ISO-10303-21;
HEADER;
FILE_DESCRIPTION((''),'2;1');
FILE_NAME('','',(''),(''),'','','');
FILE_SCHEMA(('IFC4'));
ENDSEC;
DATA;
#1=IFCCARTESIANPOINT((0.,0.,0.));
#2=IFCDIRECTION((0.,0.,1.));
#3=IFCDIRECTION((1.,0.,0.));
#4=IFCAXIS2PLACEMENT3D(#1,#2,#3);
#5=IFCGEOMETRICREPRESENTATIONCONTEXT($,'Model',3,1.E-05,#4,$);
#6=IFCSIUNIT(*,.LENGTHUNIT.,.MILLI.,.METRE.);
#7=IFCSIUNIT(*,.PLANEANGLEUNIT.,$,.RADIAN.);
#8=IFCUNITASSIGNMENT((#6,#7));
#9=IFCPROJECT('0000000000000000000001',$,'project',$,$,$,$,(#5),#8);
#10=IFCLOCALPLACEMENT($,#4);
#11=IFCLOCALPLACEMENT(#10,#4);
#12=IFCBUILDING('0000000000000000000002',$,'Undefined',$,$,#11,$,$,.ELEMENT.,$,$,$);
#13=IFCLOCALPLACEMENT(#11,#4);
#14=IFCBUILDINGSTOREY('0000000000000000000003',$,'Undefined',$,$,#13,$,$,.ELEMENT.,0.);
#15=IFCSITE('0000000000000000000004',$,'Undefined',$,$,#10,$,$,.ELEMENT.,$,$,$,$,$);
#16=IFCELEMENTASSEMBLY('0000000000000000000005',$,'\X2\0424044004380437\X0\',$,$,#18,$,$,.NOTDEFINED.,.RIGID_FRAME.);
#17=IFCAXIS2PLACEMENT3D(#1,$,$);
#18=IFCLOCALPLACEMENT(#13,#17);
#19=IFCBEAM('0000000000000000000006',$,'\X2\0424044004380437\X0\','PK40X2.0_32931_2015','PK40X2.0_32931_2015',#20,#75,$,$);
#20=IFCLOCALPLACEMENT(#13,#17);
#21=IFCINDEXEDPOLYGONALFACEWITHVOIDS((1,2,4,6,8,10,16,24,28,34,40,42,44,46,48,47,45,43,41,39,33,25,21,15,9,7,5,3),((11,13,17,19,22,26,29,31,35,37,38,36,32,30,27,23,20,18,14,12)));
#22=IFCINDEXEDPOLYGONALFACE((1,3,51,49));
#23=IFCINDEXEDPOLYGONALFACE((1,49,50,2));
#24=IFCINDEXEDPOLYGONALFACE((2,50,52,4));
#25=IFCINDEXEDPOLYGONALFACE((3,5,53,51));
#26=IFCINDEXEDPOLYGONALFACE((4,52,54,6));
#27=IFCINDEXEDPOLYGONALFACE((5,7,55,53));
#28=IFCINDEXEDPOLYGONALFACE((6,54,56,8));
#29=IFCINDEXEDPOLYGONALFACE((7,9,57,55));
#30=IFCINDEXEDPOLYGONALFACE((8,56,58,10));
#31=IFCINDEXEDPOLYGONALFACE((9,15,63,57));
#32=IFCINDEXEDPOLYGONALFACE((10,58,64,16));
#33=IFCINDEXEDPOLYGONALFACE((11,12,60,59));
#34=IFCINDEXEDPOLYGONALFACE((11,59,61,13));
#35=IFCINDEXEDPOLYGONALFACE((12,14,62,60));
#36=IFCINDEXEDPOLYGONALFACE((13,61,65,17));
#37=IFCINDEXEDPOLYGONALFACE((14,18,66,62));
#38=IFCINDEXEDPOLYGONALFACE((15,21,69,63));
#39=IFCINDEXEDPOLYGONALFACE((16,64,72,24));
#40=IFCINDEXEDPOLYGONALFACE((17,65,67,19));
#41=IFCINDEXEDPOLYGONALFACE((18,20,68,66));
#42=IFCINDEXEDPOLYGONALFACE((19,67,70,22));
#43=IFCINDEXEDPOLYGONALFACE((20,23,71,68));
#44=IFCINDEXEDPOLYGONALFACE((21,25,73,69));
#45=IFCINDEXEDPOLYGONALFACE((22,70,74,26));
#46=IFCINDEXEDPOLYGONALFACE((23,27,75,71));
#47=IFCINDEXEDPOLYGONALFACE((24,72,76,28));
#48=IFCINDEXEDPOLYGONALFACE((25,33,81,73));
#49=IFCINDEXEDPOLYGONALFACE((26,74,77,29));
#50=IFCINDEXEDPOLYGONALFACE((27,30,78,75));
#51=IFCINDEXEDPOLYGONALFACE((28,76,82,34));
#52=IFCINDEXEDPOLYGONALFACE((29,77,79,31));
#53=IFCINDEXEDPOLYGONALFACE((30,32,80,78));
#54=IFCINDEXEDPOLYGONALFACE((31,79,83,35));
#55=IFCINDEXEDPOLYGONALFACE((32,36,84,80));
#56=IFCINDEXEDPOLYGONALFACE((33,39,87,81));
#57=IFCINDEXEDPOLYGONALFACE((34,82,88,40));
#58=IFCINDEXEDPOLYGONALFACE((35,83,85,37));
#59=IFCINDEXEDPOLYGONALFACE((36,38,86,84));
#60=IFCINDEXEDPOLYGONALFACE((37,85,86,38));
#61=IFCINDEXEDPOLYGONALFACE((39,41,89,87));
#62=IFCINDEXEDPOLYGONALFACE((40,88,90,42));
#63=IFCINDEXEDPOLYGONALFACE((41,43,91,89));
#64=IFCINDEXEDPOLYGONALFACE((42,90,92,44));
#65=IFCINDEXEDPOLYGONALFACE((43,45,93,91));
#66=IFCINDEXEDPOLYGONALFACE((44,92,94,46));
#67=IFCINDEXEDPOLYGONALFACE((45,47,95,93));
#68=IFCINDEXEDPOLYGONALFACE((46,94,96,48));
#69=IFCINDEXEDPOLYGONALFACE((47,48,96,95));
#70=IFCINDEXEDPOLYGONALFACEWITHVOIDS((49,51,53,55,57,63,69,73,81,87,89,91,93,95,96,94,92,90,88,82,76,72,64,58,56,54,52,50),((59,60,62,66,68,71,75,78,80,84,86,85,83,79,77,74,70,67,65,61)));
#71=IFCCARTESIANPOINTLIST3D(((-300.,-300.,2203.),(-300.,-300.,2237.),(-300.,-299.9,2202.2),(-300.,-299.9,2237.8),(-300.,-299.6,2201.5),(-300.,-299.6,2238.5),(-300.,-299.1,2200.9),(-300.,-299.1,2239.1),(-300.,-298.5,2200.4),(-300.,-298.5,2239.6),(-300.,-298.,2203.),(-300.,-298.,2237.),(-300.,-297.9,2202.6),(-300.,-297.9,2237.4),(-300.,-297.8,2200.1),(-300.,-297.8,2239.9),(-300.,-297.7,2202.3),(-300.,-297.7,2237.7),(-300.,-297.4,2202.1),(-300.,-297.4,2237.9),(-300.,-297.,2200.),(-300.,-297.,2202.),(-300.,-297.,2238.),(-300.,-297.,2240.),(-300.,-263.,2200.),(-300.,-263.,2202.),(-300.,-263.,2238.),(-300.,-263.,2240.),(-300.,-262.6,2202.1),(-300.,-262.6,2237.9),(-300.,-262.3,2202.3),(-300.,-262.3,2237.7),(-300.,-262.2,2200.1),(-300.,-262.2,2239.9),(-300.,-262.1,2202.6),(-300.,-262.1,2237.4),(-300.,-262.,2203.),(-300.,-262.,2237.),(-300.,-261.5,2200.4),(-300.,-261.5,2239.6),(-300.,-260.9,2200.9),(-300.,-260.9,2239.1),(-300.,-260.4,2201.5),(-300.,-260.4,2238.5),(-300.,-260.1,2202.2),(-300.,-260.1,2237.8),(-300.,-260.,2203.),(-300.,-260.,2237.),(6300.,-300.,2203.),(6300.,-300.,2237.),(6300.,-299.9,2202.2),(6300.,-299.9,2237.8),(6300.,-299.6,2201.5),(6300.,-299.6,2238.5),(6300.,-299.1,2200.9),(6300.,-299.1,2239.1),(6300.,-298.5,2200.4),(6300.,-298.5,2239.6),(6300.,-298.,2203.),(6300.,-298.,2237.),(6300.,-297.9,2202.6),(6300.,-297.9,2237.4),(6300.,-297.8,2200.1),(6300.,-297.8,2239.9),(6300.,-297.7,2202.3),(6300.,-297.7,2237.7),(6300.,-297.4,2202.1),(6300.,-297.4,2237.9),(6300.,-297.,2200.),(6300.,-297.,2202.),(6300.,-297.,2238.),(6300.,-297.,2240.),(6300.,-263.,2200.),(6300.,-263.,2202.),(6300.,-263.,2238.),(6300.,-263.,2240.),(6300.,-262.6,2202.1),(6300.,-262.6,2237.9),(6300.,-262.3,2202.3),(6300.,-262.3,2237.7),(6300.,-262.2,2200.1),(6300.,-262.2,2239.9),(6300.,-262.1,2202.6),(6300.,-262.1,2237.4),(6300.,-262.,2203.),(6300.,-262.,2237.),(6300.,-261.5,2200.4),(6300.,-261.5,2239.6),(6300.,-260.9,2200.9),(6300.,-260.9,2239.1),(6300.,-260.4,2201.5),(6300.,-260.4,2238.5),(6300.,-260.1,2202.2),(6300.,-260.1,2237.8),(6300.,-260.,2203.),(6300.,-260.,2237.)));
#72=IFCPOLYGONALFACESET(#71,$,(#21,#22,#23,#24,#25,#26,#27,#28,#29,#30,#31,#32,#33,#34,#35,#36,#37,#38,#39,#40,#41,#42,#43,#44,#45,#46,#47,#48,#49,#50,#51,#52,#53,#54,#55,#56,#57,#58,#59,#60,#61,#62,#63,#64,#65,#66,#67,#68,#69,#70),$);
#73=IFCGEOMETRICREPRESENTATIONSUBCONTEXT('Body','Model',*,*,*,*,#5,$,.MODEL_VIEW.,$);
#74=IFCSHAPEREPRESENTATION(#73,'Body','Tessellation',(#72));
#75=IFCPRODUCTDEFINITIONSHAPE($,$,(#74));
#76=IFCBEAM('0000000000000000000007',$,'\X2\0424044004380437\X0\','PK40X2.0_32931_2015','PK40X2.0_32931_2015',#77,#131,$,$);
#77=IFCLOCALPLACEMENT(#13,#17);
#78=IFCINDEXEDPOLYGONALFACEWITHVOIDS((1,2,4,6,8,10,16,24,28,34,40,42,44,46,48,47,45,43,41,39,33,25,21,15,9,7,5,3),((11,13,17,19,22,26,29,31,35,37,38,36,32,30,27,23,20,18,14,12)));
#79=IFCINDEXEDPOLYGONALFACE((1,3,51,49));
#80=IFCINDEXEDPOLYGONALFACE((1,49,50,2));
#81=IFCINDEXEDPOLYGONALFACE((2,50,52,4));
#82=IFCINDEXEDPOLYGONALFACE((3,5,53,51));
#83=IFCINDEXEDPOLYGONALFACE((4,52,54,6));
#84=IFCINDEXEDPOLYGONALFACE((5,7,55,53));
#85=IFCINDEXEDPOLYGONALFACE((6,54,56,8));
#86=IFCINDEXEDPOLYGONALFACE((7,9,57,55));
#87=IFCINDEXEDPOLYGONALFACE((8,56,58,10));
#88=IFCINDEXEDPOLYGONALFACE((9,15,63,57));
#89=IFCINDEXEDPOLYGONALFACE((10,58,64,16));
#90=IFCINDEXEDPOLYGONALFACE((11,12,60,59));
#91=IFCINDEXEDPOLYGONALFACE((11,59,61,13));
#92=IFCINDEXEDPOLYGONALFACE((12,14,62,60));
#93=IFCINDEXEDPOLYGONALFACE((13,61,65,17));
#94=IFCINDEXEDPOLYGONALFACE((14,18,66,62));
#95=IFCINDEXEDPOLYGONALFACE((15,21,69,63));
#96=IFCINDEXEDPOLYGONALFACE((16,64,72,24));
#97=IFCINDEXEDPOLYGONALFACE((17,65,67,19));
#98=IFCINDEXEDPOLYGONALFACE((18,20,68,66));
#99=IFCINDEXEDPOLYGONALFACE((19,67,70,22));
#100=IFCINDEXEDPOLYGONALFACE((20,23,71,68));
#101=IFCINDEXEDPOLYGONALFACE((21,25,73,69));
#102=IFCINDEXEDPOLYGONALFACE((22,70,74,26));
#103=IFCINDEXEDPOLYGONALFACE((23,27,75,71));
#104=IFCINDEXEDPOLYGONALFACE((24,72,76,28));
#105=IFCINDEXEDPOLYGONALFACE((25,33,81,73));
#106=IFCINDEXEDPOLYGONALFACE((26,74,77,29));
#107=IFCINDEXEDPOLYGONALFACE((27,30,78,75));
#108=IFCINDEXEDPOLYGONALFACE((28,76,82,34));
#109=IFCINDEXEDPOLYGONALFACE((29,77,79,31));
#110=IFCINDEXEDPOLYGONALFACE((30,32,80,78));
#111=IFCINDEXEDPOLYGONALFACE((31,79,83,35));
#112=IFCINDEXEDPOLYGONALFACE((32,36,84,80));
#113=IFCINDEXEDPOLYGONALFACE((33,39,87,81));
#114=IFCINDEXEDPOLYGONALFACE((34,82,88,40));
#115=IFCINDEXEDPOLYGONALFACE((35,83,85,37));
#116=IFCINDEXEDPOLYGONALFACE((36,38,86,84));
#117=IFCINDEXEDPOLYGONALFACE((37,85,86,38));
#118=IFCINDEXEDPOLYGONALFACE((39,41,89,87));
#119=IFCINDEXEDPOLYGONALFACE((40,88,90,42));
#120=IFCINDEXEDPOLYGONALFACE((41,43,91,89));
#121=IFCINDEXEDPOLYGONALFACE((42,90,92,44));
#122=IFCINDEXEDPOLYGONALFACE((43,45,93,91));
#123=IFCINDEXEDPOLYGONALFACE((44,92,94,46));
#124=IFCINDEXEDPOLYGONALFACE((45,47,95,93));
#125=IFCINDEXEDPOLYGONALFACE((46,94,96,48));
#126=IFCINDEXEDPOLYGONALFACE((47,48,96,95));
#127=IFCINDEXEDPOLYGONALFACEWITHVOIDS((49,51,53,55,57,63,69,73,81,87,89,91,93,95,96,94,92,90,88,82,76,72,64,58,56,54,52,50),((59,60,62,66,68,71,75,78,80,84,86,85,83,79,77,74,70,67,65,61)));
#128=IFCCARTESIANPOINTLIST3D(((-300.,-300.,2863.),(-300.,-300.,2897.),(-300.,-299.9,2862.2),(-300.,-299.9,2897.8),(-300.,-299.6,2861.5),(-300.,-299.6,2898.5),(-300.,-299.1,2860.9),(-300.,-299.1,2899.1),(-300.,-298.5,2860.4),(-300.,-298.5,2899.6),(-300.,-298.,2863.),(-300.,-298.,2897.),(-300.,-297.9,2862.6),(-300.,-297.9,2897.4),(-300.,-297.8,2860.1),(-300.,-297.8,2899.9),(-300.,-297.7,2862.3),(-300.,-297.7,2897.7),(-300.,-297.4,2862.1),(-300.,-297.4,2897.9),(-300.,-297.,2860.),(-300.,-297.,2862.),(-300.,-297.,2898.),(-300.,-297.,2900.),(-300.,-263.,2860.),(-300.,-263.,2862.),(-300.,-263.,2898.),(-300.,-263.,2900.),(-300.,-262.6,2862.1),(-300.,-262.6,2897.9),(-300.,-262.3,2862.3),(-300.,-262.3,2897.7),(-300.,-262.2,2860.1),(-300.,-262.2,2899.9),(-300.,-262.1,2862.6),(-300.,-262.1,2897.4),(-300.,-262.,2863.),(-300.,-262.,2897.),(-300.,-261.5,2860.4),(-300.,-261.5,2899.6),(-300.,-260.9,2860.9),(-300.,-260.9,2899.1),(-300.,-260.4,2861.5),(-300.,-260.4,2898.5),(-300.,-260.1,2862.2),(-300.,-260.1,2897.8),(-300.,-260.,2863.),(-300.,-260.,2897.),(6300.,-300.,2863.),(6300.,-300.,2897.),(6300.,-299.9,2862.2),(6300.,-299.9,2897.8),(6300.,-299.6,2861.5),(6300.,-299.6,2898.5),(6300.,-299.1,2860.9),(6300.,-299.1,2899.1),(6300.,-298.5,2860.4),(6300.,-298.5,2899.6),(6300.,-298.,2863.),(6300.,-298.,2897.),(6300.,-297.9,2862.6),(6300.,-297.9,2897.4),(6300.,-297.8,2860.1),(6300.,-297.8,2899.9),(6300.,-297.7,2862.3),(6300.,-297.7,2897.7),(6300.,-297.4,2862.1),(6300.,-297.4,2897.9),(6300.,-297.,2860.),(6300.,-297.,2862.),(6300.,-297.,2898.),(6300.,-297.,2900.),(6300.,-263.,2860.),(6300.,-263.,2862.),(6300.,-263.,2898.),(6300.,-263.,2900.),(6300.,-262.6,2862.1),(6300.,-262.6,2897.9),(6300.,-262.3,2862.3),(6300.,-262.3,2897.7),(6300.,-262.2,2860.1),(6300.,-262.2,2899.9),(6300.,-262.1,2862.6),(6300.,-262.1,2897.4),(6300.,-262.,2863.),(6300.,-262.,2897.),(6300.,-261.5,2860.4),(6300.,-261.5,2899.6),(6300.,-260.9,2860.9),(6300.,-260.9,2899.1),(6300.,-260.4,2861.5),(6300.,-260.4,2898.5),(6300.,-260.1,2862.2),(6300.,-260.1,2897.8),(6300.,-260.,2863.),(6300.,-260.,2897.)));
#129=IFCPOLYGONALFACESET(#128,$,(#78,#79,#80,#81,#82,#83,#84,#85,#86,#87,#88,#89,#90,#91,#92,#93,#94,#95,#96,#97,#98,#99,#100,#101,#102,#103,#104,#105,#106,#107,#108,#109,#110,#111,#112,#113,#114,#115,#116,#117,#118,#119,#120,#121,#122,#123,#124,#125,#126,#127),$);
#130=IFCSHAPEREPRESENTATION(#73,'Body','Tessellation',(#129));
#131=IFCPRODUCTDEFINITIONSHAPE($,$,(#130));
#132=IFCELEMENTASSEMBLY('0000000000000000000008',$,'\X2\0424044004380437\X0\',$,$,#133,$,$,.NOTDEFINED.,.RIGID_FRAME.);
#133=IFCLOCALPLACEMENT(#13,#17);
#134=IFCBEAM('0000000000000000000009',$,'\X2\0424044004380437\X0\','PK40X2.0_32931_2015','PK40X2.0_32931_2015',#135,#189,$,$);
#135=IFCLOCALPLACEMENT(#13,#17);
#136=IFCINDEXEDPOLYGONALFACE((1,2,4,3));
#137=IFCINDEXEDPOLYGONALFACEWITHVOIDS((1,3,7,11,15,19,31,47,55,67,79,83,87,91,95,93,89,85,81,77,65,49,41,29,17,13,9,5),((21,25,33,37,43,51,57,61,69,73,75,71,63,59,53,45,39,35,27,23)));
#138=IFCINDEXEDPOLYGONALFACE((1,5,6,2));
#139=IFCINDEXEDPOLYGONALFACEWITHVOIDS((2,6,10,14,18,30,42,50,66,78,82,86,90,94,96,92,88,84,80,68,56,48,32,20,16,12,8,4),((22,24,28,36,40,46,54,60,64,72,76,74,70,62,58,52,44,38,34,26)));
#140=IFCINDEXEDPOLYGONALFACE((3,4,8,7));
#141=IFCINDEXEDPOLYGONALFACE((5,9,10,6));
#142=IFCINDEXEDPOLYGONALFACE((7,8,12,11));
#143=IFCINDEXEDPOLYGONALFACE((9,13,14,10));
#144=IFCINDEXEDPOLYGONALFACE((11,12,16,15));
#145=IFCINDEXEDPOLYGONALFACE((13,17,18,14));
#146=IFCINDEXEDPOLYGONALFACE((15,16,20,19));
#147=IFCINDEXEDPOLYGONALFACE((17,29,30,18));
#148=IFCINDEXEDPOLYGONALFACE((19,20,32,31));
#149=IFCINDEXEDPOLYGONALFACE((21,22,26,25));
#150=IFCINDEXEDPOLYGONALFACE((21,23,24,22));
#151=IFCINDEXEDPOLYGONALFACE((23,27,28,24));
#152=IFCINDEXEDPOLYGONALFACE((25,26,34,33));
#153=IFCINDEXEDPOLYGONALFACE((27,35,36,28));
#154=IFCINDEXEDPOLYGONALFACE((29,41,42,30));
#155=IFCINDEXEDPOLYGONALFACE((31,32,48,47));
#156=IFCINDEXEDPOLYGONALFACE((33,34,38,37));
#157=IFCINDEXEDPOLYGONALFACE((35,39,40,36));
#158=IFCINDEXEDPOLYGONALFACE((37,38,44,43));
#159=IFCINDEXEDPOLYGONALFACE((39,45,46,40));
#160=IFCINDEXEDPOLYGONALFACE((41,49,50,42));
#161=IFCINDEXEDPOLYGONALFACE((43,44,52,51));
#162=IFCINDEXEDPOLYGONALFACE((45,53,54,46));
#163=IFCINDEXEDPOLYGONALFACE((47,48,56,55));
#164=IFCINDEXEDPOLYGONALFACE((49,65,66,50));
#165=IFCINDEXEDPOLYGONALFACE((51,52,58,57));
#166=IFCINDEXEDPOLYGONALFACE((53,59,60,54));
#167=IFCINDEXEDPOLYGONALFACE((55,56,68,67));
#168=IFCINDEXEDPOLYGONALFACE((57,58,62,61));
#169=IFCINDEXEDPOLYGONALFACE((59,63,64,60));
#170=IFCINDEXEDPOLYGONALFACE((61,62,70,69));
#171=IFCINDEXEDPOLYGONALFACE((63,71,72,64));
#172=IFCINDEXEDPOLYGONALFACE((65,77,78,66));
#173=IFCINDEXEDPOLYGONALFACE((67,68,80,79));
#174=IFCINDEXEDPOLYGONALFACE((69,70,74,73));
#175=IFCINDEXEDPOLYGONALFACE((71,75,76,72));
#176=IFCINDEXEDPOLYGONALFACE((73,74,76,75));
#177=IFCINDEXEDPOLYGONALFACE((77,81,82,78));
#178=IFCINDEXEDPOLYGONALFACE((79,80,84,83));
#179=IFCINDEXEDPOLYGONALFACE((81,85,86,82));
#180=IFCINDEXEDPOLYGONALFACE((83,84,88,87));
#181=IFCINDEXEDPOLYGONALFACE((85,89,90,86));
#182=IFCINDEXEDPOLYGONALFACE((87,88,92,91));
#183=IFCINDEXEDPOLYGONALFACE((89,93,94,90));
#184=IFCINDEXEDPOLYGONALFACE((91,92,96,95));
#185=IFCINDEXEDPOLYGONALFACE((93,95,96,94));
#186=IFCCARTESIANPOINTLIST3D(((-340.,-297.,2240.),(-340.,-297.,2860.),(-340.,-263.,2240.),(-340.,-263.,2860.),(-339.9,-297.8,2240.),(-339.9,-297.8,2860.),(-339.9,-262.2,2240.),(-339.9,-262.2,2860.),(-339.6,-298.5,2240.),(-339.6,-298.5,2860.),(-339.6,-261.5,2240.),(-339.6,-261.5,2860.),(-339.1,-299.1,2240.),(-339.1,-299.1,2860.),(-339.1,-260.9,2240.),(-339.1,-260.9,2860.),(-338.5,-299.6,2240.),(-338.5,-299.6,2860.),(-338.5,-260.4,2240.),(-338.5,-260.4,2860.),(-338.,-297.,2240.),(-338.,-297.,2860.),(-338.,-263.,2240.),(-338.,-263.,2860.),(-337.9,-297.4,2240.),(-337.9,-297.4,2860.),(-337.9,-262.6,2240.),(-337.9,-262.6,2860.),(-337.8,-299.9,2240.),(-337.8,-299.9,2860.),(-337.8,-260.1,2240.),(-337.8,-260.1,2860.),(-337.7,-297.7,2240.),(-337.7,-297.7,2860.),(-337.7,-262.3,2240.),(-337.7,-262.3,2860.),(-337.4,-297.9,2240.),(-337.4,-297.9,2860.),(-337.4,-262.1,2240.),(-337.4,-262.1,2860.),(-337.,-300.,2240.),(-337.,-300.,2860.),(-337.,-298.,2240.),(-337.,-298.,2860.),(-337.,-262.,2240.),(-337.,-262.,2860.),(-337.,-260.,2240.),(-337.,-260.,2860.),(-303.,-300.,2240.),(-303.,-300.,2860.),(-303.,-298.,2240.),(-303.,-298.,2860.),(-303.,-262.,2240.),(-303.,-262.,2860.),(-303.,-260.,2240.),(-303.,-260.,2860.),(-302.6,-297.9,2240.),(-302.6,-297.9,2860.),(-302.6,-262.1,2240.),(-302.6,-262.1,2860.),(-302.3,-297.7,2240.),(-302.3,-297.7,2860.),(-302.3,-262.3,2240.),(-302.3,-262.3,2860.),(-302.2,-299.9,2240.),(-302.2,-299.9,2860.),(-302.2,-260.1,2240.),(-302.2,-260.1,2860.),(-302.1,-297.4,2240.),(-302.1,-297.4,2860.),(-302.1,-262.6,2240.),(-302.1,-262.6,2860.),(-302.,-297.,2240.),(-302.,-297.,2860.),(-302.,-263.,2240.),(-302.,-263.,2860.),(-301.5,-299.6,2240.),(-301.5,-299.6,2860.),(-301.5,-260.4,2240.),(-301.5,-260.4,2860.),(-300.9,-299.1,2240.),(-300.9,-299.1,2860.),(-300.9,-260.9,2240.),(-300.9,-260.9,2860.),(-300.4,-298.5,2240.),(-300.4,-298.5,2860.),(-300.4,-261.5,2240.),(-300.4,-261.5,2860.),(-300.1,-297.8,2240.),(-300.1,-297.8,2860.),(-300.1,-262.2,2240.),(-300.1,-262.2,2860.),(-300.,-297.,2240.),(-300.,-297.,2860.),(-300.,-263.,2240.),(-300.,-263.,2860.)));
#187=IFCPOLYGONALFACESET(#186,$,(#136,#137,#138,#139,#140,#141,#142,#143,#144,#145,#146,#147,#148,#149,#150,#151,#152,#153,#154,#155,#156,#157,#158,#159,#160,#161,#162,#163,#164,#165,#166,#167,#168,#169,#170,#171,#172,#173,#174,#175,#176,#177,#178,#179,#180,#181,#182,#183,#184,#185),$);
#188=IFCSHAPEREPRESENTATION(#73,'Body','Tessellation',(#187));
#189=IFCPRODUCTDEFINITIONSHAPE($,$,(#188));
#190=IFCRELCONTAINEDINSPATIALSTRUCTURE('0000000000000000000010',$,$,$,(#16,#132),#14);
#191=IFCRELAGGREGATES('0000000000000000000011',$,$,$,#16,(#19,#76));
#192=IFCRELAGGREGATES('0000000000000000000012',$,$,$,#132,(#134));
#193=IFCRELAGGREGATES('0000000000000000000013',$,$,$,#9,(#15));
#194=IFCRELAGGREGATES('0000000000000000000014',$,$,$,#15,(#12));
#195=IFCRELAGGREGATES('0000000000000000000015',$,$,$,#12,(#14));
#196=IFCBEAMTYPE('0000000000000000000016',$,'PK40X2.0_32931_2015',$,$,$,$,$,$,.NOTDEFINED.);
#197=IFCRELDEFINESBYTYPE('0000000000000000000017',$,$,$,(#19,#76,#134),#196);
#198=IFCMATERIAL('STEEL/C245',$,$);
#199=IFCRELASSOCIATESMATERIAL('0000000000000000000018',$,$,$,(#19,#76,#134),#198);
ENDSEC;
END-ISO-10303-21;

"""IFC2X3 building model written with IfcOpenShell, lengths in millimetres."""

from ifc_helpers import new_model, si_unit, frame, origin_with_axes, origin_2d_with_axis, place, context, subcontext, project, spatial, hollow_rectangle, extrude, material, type_object, element, aggregate, save


model = new_model("IFC2X3")

# Units and contexts
model_context = context("Model", 3, precision=1e-05, world=origin_with_axes())
body_context = subcontext(model_context, "Body", "Model", "MODEL_VIEW")
ifc_project = project(units=[si_unit("LENGTHUNIT", "METRE", prefix="MILLI"), si_unit("PLANEANGLEUNIT", "RADIAN")], contexts=[model_context])

# Site, building, storey
site_placement = place(None, origin_with_axes())
site = spatial("IfcSite", under=ifc_project, at=site_placement, Name="Undefined", CompositionType="ELEMENT")
building_placement = place(site_placement, origin_with_axes())
building = spatial("IfcBuilding", under=site, at=building_placement, Name="Undefined", CompositionType="ELEMENT")
storey_placement = place(building_placement, origin_with_axes())
storey = spatial("IfcBuildingStorey", under=building, at=storey_placement, Name="Undefined", CompositionType="ELEMENT", Elevation=0.0)

# Shared definitions
ifc_material_1 = material(Name="STEEL/C245")

# Shared definitions
beam_type_1 = type_object("IfcBeamType", Name="PK40X2.0_32931_2015", PredefinedType="NOTDEFINED")

# Element assemblies, beams
assembly_1_placement = place(storey_placement, origin_with_axes())
assembly_1 = element("IfcElementAssembly", 1, at=assembly_1_placement, inside=storey, Name="Фриз", AssemblyPlace="NOTDEFINED", PredefinedType="RIGID_FRAME")
beam_1_placement = place(assembly_1_placement, frame((-300.0, -280.0, 2220.0), z_axis=(0.0, 0.0, 1.0), x_axis=(1.0, 0.0, 0.0)))
beam_1 = element("IfcBeam", 2, at=beam_1_placement, type_object=beam_type_1, material=ifc_material_1, Name="Фриз", Description="PK40X2.0_32931_2015", ObjectType="PK40X2.0_32931_2015", context=body_context, shape_type="SweptSolid", body=[
    extrude(hollow_rectangle(XDim=40.0, YDim=40.0, WallThickness=2.0, InnerFilletRadius=1.0, OuterFilletRadius=3.0, at=origin_2d_with_axis()), frame((6600.0, 0.0, 0.0), z_axis=(-1.0, 0.0, 0.0), x_axis=(0.0, -1.0, 0.0)), (0.0, 0.0, 1.0), 6600.0),
])
beam_2_placement = place(assembly_1_placement, frame((-300.0, -280.0, 2880.0), z_axis=(0.0, 0.0, 1.0), x_axis=(1.0, 0.0, 0.0)))
beam_2 = element("IfcBeam", 3, at=beam_2_placement, type_object=beam_type_1, material=ifc_material_1, Name="Фриз", Description="PK40X2.0_32931_2015", ObjectType="PK40X2.0_32931_2015", context=body_context, shape_type="SweptSolid", body=[
    extrude(hollow_rectangle(XDim=40.0, YDim=40.0, WallThickness=2.0, InnerFilletRadius=1.0, OuterFilletRadius=3.0, at=origin_2d_with_axis()), frame((6600.0, 0.0, 0.0), z_axis=(-1.0, 0.0, 0.0), x_axis=(0.0, -1.0, 0.0)), (0.0, 0.0, 1.0), 6600.0),
])
aggregate(assembly_1, [beam_1, beam_2])
assembly_2_placement = place(storey_placement, origin_with_axes())
assembly_2 = element("IfcElementAssembly", 4, at=assembly_2_placement, inside=storey, Name="Фриз", AssemblyPlace="NOTDEFINED", PredefinedType="RIGID_FRAME")
beam_3_placement = place(assembly_2_placement, frame((-320.0, -280.0, 2860.0), z_axis=(1.0, 0.0, 0.0), x_axis=(0.0, 0.0, -1.0)))
beam_3 = element("IfcBeam", 5, at=beam_3_placement, type_object=beam_type_1, material=ifc_material_1, Name="Фриз", Description="PK40X2.0_32931_2015", ObjectType="PK40X2.0_32931_2015", context=body_context, shape_type="SweptSolid", body=[
    extrude(hollow_rectangle(XDim=40.0, YDim=40.0, WallThickness=2.0, InnerFilletRadius=1.0, OuterFilletRadius=3.0, at=origin_2d_with_axis()), frame((620.0, 0.0, 0.0), z_axis=(-1.0, 0.0, 0.0), x_axis=(0.0, -1.0, 0.0)), (0.0, 0.0, 1.0), 620.0),
])
aggregate(assembly_2, [beam_3])

save(model, "model.ifc")
